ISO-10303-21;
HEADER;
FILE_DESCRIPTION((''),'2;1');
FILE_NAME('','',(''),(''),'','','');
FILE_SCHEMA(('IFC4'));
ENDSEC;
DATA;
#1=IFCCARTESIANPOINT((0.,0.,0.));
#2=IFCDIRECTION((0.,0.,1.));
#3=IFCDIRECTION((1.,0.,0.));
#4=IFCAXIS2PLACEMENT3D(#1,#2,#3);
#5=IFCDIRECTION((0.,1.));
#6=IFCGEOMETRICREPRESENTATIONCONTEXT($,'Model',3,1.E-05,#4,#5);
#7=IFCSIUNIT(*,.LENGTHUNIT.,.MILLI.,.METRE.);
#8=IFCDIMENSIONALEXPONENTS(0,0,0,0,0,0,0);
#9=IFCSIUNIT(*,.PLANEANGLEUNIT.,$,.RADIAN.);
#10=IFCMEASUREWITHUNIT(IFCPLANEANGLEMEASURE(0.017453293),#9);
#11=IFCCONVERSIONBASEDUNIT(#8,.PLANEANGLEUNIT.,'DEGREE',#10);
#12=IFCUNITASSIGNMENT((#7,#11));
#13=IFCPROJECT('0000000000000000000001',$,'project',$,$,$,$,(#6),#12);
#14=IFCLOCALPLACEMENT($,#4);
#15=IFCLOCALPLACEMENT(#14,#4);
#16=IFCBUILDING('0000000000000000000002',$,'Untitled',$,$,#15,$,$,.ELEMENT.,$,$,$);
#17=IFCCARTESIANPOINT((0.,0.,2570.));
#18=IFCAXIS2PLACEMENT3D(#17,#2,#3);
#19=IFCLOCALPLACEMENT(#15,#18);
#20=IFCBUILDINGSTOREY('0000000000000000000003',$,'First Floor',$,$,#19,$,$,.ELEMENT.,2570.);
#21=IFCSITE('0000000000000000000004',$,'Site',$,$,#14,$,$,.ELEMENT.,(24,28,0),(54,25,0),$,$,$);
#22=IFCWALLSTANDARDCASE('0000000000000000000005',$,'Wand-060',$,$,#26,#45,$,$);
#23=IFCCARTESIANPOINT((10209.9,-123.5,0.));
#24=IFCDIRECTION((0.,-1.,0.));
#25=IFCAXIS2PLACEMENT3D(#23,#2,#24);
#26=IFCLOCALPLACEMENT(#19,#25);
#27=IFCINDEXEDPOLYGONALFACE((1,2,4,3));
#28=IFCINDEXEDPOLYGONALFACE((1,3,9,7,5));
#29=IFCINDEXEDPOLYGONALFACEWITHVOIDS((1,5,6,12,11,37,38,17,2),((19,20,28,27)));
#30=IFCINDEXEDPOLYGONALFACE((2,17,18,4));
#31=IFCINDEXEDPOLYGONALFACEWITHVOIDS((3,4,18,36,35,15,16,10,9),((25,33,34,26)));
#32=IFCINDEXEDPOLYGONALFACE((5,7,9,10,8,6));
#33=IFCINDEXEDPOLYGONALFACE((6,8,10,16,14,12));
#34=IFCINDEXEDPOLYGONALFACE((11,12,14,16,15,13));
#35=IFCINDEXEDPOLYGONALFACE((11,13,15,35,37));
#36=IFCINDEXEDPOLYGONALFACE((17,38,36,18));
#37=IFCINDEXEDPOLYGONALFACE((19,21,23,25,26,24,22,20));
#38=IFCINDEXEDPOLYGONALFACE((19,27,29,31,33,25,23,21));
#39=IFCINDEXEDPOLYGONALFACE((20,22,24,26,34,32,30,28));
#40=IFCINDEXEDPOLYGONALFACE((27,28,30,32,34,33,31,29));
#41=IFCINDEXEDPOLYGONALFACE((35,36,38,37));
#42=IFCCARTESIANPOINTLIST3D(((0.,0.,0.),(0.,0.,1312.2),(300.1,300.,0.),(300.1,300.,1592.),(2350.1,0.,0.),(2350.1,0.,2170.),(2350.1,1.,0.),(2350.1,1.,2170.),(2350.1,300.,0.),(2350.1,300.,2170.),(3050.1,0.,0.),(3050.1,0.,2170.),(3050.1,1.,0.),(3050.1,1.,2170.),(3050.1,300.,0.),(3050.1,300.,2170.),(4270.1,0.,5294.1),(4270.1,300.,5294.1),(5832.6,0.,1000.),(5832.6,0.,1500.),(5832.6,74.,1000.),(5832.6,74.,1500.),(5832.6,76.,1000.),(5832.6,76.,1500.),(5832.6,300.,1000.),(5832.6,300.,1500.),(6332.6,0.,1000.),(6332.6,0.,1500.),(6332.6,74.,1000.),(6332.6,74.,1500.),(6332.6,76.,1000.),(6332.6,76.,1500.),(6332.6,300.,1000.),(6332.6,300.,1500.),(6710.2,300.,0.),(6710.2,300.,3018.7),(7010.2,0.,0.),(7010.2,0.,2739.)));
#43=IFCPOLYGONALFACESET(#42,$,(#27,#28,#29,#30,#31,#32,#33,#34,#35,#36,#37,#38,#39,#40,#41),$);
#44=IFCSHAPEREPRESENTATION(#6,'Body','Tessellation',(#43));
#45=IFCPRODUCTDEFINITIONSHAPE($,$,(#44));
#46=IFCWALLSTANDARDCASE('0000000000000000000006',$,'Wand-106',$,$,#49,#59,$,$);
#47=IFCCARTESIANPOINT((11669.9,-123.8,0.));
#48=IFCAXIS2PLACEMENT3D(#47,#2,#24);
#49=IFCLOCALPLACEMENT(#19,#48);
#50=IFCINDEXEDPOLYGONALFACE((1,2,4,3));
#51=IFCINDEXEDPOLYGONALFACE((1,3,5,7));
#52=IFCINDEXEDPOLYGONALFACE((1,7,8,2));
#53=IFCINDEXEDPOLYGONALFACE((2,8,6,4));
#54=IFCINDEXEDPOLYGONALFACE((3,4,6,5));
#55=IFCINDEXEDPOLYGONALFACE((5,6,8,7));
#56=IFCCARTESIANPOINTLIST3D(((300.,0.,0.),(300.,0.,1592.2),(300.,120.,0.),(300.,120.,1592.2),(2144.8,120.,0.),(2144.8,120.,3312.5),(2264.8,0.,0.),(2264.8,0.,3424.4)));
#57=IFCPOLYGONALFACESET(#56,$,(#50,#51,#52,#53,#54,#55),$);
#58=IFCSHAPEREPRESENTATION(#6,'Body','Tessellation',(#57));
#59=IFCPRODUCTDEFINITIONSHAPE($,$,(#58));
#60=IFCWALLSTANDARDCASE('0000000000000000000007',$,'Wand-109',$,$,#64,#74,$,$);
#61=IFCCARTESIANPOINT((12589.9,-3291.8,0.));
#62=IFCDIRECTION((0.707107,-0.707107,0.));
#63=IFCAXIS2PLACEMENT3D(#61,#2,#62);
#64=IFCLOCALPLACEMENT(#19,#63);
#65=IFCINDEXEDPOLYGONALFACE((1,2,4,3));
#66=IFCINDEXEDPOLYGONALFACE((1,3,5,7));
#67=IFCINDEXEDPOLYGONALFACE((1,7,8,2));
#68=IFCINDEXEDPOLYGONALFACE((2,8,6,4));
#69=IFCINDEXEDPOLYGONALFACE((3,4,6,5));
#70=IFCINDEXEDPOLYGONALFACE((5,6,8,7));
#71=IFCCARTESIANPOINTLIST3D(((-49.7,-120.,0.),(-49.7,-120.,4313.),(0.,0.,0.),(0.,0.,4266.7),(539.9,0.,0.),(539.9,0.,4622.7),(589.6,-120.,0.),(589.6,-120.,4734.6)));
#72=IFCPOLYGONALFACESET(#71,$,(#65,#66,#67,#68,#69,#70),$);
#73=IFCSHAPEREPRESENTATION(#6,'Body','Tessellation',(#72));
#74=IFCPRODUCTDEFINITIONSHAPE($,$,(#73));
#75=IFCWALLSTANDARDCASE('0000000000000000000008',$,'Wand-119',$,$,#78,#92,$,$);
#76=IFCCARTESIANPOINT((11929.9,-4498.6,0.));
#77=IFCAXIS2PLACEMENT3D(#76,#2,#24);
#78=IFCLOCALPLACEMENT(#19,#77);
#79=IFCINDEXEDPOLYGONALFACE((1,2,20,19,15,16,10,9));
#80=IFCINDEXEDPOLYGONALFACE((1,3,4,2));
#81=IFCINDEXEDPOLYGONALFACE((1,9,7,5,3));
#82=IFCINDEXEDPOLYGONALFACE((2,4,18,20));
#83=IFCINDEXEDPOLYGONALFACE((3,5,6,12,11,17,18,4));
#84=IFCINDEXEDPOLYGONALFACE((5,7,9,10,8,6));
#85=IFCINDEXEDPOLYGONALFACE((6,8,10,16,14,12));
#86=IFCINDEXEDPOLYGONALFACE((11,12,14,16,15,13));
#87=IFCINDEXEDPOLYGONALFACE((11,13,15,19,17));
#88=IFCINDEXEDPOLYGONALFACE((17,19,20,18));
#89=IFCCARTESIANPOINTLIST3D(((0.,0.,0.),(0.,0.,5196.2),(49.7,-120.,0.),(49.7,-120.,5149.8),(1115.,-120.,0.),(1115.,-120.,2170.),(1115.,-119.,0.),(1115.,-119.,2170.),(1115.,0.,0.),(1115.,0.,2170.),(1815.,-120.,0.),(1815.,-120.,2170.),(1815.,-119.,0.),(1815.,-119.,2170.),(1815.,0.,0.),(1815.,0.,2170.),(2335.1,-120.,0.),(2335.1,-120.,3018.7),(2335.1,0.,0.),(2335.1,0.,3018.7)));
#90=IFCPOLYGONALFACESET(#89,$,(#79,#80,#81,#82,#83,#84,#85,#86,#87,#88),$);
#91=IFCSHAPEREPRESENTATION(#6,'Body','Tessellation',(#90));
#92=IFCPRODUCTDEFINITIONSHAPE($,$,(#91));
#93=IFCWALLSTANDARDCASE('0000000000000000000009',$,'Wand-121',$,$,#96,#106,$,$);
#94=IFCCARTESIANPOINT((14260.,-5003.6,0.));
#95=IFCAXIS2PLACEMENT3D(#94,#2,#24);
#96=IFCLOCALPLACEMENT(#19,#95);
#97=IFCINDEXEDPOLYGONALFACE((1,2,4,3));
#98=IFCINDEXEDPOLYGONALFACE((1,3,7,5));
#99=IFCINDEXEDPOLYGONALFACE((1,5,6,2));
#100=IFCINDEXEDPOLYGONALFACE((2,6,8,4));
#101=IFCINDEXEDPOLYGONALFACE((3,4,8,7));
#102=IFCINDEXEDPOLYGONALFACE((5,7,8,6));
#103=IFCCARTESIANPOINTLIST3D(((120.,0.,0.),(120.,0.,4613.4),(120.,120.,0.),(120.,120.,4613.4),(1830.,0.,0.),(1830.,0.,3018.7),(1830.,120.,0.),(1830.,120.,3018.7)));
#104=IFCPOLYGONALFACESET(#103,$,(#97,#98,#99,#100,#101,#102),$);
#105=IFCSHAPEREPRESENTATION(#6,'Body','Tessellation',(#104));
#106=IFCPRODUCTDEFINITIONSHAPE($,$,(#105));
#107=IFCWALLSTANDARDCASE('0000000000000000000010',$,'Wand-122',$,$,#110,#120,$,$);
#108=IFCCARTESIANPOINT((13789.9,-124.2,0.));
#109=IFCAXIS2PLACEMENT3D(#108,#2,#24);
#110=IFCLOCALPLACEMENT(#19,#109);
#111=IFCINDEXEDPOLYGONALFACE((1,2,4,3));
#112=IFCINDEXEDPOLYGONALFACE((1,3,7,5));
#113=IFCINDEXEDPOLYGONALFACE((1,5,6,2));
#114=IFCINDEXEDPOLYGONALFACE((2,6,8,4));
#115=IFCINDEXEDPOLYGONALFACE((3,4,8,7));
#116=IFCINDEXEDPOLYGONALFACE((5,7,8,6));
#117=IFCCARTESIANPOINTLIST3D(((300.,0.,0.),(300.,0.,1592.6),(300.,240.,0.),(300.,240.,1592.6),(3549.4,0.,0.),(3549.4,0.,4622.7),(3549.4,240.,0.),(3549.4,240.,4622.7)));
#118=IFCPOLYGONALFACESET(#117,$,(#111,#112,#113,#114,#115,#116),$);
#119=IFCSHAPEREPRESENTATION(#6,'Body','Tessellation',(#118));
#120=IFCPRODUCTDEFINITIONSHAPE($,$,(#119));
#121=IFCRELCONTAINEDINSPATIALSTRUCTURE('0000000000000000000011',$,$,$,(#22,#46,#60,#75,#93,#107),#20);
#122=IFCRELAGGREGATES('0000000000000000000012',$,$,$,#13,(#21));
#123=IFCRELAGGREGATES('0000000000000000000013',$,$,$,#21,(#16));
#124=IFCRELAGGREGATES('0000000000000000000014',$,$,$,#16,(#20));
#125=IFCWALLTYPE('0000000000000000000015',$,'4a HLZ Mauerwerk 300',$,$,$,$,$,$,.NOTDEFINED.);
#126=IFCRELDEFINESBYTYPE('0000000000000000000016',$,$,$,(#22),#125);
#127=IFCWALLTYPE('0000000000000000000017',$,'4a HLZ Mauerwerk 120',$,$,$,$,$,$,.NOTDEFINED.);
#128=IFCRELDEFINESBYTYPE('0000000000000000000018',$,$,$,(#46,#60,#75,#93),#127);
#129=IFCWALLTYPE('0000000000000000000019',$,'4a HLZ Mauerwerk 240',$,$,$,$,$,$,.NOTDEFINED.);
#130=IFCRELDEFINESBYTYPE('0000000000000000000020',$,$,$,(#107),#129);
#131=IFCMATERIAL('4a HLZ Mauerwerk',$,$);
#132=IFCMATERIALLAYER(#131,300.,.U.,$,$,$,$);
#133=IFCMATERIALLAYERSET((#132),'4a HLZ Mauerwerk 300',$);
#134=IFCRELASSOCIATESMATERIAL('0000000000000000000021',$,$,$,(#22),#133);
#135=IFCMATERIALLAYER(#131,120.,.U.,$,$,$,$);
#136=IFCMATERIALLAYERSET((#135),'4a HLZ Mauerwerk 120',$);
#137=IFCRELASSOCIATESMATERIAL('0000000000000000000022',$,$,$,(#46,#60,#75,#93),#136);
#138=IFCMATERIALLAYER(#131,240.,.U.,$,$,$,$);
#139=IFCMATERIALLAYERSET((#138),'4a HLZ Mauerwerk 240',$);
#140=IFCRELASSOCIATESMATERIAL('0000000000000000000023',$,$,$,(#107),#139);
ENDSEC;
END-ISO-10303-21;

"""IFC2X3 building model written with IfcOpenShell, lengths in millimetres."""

from ifc_helpers import new_model, entity, si_unit, converted_unit, direction, frame, origin_with_axes, origin_2d_with_axis, place, context, project, spatial, polyline, rectangle, outline, extrude, clip, halfspace, bounded_halfspace, material, layer, layer_set, layer_usage, type_object, element, save


model = new_model("IFC2X3")

# Units and contexts
model_context = context("Model", 3, precision=1e-05, world=origin_with_axes(), true_north=direction((0.0, 1.0)))
ifc_project = project(units=[si_unit("LENGTHUNIT", "METRE", prefix="MILLI"), converted_unit("PLANEANGLEUNIT", "DEGREE", entity("IfcPlaneAngleMeasure", 0.017453293), si_unit("PLANEANGLEUNIT", "RADIAN"), dimensions=[0, 0, 0, 0, 0, 0, 0])], contexts=[model_context])

# Site, building, storey
site_placement = place(None, origin_with_axes())
site = spatial("IfcSite", under=ifc_project, at=site_placement, Name="Site", CompositionType="ELEMENT", RefLatitude=(24, 28, 0), RefLongitude=(54, 25, 0))
building_placement = place(site_placement, origin_with_axes())
building = spatial("IfcBuilding", under=site, at=building_placement, Name="Untitled", CompositionType="ELEMENT")
storey_placement = place(building_placement, frame((0.0, 0.0, 2570.0), z_axis=(0.0, 0.0, 1.0), x_axis=(1.0, 0.0, 0.0)))
storey = spatial("IfcBuildingStorey", under=building, at=storey_placement, Name="First Floor", CompositionType="ELEMENT", Elevation=2570.0)

# Shared definitions
ifc_material_1 = material(Name="4a HLZ Mauerwerk")

# Wall, openings
ifc_layer_1 = layer(ifc_material_1, 300.0, ventilated="UNKNOWN")
ifc_layer_set_1 = layer_set([ifc_layer_1], Name="4a HLZ Mauerwerk 300")
ifc_layer_usage_1 = layer_usage(ifc_layer_set_1, "AXIS2", "POSITIVE", 0.0)
wall_type_1 = type_object("IfcWallType", Name="4a HLZ Mauerwerk 300", PredefinedType="NOTDEFINED")
wall_1_placement = place(storey_placement, frame((10209.9, -123.5, 0.0), z_axis=(0.0, 0.0, 1.0), x_axis=(0.0, -1.0, 0.0)))
wall_1 = element("IfcWallStandardCase", 1, at=wall_1_placement, inside=storey, type_object=wall_type_1, material=ifc_layer_usage_1, Name="Wand-060", context=model_context, shape_type="Clipping", body=[
    clip(clip(clip(extrude(outline(polyline([(0.0, 0.0), (7010.2, 0.0), (6710.2, 300.0), (300.1, 300.0), (0.0, 0.0)])), origin_with_axes(), (0.0, 0.0, 1.0), 5316.0), bounded_halfspace(frame((-654.5, 0.0, 701.9), z_axis=(0.681998, -0.000006, -0.731354), x_axis=(0.731354, 0.0, 0.681998)), True, origin_with_axes(), polyline([(0.0, 0.0), (4270.1, 0.0), (4270.1, 300.0), (0.0, 300.0), (0.0, 0.0)]))), bounded_halfspace(frame((-654.5, 0.0, 701.9), z_axis=(0.681998, -0.000006, -0.731354), x_axis=(0.731354, 0.0, 0.681998)), True, origin_with_axes(), polyline([(0.0, 0.0), (4270.1, 0.0), (4270.1, 300.0), (0.0, 300.0), (0.0, 0.0)]))), bounded_halfspace(frame((4626.7, 0.0, 4961.5), z_axis=(-0.681998, 0.000006, -0.731354), x_axis=(0.731354, 0.0, -0.681998)), True, origin_with_axes(), polyline([(4270.1, 0.0), (7010.2, 0.0), (7010.2, 300.0), (4270.1, 300.0), (4270.1, 0.0)]))),
])
opening_1_placement = place(wall_1_placement, frame((6082.6, 0.0, 1000.0), z_axis=(0.0, 0.0, 1.0), x_axis=(1.0, 0.0, 0.0)))
element("IfcOpeningElement", 2, at=opening_1_placement, cuts=wall_1, context=model_context, shape_type="SweptSolid", body=[
    extrude(rectangle(XDim=500.0, YDim=500.0, at=origin_2d_with_axis()), frame((0.0, -526.0, 250.0), z_axis=(0.0, 1.0, 0.0), x_axis=(1.0, 0.0, 0.0)), (0.0, 0.0, 1.0), 602.0),
    extrude(rectangle(XDim=500.0, YDim=500.0, at=origin_2d_with_axis()), frame((0.0, 676.0, 250.0), z_axis=(0.0, -1.0, 0.0), x_axis=(1.0, 0.0, 0.0)), (0.0, 0.0, 1.0), 602.0),
])
opening_2_placement = place(wall_1_placement, frame((2700.1, 0.0, 0.0), z_axis=(0.0, 0.0, 1.0), x_axis=(1.0, 0.0, 0.0)))
element("IfcOpeningElement", 3, at=opening_2_placement, cuts=wall_1, context=model_context, shape_type="SweptSolid", body=[
    extrude(rectangle(XDim=700.0, YDim=2170.0, at=origin_2d_with_axis()), frame((0.0, -601.0, 1085.0), z_axis=(0.0, 1.0, 0.0), x_axis=(1.0, 0.0, 0.0)), (0.0, 0.0, 1.0), 602.0),
    extrude(rectangle(XDim=700.0, YDim=2170.0, at=origin_2d_with_axis()), frame((0.0, 601.0, 1085.0), z_axis=(0.0, -1.0, 0.0), x_axis=(1.0, 0.0, 0.0)), (0.0, 0.0, 1.0), 602.0),
])

# Wall
ifc_layer_2 = layer(ifc_material_1, 120.0, ventilated="UNKNOWN")
ifc_layer_set_2 = layer_set([ifc_layer_2], Name="4a HLZ Mauerwerk 120")
ifc_layer_usage_2 = layer_usage(ifc_layer_set_2, "AXIS2", "POSITIVE", 0.0)
wall_type_2 = type_object("IfcWallType", Name="4a HLZ Mauerwerk 120", PredefinedType="NOTDEFINED")
wall_2_placement = place(storey_placement, frame((11669.9, -123.8, 0.0), z_axis=(0.0, 0.0, 1.0), x_axis=(0.0, -1.0, 0.0)))
element("IfcWallStandardCase", 4, at=wall_2_placement, inside=storey, type_object=wall_type_2, material=ifc_layer_usage_2, Name="Wand-106", context=model_context, shape_type="Clipping", body=[
    clip(extrude(outline(polyline([(300.0, 0.0), (2264.8, 0.0), (2144.8, 120.0), (300.0, 120.0), (300.0, 0.0)])), origin_with_axes(), (0.0, 0.0, 1.0), 5316.0), halfspace(frame((-654.6, 0.0, 702.0), z_axis=(0.681998, 0.0, -0.731354), x_axis=(0.731354, 0.0, 0.681998)), True)),
])

# Wall
ifc_layer_usage_3 = layer_usage(ifc_layer_set_2, "AXIS2", "NEGATIVE", 0.0)
wall_3_placement = place(storey_placement, frame((12589.9, -3291.8, 0.0), z_axis=(0.0, 0.0, 1.0), x_axis=(0.707107, -0.707107, 0.0)))
element("IfcWallStandardCase", 5, at=wall_3_placement, inside=storey, type_object=wall_type_2, material=ifc_layer_usage_3, Name="Wand-109", context=model_context, shape_type="Clipping", body=[
    clip(extrude(outline(polyline([(-49.7, -120.0), (589.6, -120.0), (539.9, 0.0), (0.0, 0.0), (-49.7, -120.0)])), origin_with_axes(), (0.0, 0.0, 1.0), 5316.0), halfspace(frame((-1504.8, 1504.8, 2282.2), z_axis=(0.482246, -0.482246, -0.731354), x_axis=(0.0, -0.834844, 0.550486)), True)),
])

# Wall, opening
ifc_layer_usage_4 = layer_usage(ifc_layer_set_2, "AXIS2", "NEGATIVE", 0.0)
wall_4_placement = place(storey_placement, frame((11929.9, -4498.6, 0.0), z_axis=(0.0, 0.0, 1.0), x_axis=(0.0, -1.0, 0.0)))
wall_4 = element("IfcWallStandardCase", 6, at=wall_4_placement, inside=storey, type_object=wall_type_2, material=ifc_layer_usage_4, Name="Wand-119", context=model_context, shape_type="Clipping", body=[
    clip(extrude(outline(polyline([(49.7, -120.0), (2335.1, -120.0), (2335.1, 0.0), (0.0, 0.0), (49.7, -120.0)])), origin_with_axes(), (0.0, 0.0, 1.0), 5316.0), halfspace(frame((2591.8, 0.0, 2779.3), z_axis=(-0.681998, 0.0, -0.731354), x_axis=(0.731354, 0.0, -0.681998)), True)),
])
opening_3_placement = place(wall_4_placement, frame((1465.0, 0.0, 0.0), z_axis=(0.0, 0.0, 1.0), x_axis=(1.0, 0.0, 0.0)))
element("IfcOpeningElement", 7, at=opening_3_placement, cuts=wall_4, context=model_context, shape_type="SweptSolid", body=[
    extrude(rectangle(XDim=700.0, YDim=2170.0, at=origin_2d_with_axis()), frame((0.0, -361.0, 1085.0), z_axis=(0.0, 1.0, 0.0), x_axis=(1.0, 0.0, 0.0)), (0.0, 0.0, 1.0), 242.0),
    extrude(rectangle(XDim=700.0, YDim=2170.0, at=origin_2d_with_axis()), frame((0.0, 121.0, 1085.0), z_axis=(0.0, -1.0, 0.0), x_axis=(1.0, 0.0, 0.0)), (0.0, 0.0, 1.0), 242.0),
])

# Walls
ifc_layer_usage_5 = layer_usage(ifc_layer_set_2, "AXIS2", "POSITIVE", 0.0)
wall_5_placement = place(storey_placement, frame((14260.0, -5003.6, 0.0), z_axis=(0.0, 0.0, 1.0), x_axis=(0.0, -1.0, 0.0)))
element("IfcWallStandardCase", 8, at=wall_5_placement, inside=storey, type_object=wall_type_2, material=ifc_layer_usage_5, Name="Wand-121", context=model_context, shape_type="Clipping", body=[
    clip(extrude(outline(polyline([(120.0, 0.0), (1830.0, 0.0), (1830.0, 120.0), (120.0, 120.0), (120.0, 0.0)])), origin_with_axes(), (0.0, 0.0, 1.0), 5316.0), halfspace(frame((2356.9, 0.0, 2527.4), z_axis=(-0.681998, 0.0, -0.731354), x_axis=(0.731354, 0.0, -0.681998)), True)),
])
ifc_layer_3 = layer(ifc_material_1, 240.0, ventilated="UNKNOWN")
ifc_layer_set_3 = layer_set([ifc_layer_3], Name="4a HLZ Mauerwerk 240")
ifc_layer_usage_6 = layer_usage(ifc_layer_set_3, "AXIS2", "POSITIVE", 0.0)
wall_type_3 = type_object("IfcWallType", Name="4a HLZ Mauerwerk 240", PredefinedType="NOTDEFINED")
wall_6_placement = place(storey_placement, frame((13789.9, -124.2, 0.0), z_axis=(0.0, 0.0, 1.0), x_axis=(0.0, -1.0, 0.0)))
element("IfcWallStandardCase", 9, at=wall_6_placement, inside=storey, type_object=wall_type_3, material=ifc_layer_usage_6, Name="Wand-122", context=model_context, shape_type="Clipping", body=[
    clip(extrude(outline(polyline([(300.0, 0.0), (3549.4, 0.0), (3549.4, 240.0), (300.0, 240.0), (300.0, 0.0)])), origin_with_axes(), (0.0, 0.0, 1.0), 5316.0), halfspace(frame((-654.8, 0.0, 702.2), z_axis=(0.681998, 0.0, -0.731354), x_axis=(0.731354, 0.0, 0.681998)), True)),
])

save(model, "model.ifc")
